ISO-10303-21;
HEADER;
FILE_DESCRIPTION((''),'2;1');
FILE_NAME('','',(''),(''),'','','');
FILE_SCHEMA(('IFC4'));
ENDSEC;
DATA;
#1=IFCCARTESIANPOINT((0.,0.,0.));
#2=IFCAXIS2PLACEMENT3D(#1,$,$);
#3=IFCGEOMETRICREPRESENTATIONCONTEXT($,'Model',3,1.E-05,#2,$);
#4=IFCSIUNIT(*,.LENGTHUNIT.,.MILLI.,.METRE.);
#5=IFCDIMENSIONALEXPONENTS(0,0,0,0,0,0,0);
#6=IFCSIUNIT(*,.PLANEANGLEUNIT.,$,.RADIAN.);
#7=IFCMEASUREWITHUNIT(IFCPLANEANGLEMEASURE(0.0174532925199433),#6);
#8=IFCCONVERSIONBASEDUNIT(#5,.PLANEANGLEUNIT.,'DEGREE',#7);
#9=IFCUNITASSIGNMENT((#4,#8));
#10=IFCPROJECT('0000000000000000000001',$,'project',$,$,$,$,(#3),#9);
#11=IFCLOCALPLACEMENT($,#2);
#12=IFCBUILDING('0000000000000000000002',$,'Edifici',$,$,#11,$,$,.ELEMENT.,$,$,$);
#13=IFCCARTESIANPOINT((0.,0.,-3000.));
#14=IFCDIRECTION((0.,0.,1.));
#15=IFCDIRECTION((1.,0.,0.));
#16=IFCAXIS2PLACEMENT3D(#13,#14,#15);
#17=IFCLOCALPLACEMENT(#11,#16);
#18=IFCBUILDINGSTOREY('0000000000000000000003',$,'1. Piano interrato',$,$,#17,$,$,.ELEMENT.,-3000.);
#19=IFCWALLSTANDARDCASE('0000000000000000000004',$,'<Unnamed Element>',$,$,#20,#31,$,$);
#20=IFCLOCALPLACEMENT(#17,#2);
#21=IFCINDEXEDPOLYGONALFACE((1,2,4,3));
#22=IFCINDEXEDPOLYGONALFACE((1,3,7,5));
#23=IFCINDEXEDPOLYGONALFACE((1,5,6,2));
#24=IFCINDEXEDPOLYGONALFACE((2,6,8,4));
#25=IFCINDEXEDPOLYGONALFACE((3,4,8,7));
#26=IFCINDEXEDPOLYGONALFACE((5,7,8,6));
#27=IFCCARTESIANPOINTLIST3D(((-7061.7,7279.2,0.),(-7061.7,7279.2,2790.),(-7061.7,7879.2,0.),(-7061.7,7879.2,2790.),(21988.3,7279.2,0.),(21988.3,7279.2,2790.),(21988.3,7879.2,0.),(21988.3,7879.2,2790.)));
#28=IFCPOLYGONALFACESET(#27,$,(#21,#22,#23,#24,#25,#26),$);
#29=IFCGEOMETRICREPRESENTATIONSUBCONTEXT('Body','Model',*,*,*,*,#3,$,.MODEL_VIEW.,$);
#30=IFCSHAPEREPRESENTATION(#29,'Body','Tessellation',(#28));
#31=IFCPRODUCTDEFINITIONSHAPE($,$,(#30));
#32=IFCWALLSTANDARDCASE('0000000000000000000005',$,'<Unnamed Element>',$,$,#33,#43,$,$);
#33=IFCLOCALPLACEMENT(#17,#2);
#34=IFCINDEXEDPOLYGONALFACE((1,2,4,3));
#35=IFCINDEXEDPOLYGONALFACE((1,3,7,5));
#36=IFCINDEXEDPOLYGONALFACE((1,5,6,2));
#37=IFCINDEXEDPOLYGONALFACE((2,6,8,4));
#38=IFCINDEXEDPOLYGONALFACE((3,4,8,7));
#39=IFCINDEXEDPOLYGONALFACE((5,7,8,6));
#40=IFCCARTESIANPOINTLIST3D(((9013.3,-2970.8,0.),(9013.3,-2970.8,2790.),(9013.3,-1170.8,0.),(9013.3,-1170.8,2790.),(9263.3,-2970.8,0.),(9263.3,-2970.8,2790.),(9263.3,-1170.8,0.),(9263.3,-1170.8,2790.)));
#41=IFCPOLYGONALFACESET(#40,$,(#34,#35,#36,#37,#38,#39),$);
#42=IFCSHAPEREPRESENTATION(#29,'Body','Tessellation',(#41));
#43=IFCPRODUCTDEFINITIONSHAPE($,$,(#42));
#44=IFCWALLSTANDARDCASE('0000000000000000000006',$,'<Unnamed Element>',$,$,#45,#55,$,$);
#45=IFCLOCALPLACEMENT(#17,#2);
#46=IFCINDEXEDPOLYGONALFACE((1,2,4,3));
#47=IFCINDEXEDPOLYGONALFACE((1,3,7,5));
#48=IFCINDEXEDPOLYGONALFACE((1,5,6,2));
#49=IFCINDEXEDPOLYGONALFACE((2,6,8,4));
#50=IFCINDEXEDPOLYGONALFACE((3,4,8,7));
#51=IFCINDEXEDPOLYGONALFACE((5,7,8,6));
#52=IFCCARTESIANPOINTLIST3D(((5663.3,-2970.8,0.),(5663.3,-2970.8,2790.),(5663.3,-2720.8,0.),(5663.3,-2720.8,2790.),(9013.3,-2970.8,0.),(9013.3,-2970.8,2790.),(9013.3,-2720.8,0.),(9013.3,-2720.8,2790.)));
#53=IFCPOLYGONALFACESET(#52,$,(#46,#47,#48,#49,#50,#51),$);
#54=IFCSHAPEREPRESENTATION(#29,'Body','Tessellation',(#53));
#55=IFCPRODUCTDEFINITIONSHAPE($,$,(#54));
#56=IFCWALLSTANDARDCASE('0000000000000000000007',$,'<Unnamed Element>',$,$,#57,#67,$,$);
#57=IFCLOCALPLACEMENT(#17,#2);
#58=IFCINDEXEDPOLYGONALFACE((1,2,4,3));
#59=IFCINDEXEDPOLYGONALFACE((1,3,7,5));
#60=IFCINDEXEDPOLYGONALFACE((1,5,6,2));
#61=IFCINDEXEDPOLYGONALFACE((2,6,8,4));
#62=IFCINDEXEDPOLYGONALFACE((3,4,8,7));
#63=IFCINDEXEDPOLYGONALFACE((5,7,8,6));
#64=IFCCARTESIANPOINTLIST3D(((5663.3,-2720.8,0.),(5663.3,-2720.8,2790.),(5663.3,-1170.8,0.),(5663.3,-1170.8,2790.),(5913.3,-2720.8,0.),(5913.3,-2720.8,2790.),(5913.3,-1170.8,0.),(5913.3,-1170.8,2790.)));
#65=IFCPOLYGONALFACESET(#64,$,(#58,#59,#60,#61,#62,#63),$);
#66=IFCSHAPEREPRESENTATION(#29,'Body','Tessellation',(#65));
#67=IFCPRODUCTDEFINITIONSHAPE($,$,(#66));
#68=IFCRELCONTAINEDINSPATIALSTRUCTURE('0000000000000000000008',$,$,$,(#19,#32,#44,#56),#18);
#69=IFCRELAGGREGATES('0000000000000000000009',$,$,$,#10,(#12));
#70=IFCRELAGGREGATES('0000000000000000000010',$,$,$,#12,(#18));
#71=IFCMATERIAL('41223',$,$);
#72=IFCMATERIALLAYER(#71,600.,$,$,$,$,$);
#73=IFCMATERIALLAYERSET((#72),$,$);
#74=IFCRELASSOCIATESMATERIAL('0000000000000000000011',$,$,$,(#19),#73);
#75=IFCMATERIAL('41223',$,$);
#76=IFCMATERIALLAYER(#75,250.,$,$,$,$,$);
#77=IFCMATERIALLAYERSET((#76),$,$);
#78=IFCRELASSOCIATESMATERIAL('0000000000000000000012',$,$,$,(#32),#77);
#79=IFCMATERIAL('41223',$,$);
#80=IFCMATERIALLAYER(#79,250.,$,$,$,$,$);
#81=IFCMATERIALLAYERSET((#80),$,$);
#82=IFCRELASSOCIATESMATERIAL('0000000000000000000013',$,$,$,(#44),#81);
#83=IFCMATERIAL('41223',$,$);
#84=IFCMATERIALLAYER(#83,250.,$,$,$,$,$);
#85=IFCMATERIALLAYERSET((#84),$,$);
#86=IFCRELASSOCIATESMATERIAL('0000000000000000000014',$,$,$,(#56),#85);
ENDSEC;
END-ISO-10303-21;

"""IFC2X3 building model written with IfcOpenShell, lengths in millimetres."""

from ifc_helpers import new_model, entity, si_unit, converted_unit, frame, frame_2d, origin, origin_with_axes, place, context, subcontext, project, spatial, rectangle, extrude, material, layer, layer_set, layer_usage, element, save


model = new_model("IFC2X3")

# Units and contexts
model_context = context("Model", 3, precision=1e-05, world=origin())
body_context = subcontext(model_context, "Body", "Model", "MODEL_VIEW")
ifc_project = project(units=[si_unit("LENGTHUNIT", "METRE", prefix="MILLI"), converted_unit("PLANEANGLEUNIT", "DEGREE", entity("IfcPlaneAngleMeasure", 0.0174532925199433), si_unit("PLANEANGLEUNIT", "RADIAN"), dimensions=[0, 0, 0, 0, 0, 0, 0])], contexts=[model_context])

# Building, storey
building_placement = place(None, origin())
building = spatial("IfcBuilding", under=ifc_project, at=building_placement, Name="Edifici", CompositionType="ELEMENT")
storey_placement = place(building_placement, frame((0.0, 0.0, -3000.0), z_axis=(0.0, 0.0, 1.0), x_axis=(1.0, 0.0, 0.0)))
storey = spatial("IfcBuildingStorey", under=building, at=storey_placement, Name="1. Piano interrato", CompositionType="ELEMENT", Elevation=-3000.0)

# Walls
ifc_material_1 = material(Name="41223")
ifc_layer_1 = layer(ifc_material_1, 600.0)
ifc_layer_set_1 = layer_set([ifc_layer_1])
ifc_layer_usage_1 = layer_usage(ifc_layer_set_1, "AXIS2", "POSITIVE", 0.0)
wall_1_placement = place(storey_placement, frame((21988.3, 7879.2, 0.0), z_axis=(0.0, 0.0, 1.0), x_axis=(-1.0, 0.0, 0.0)))
element("IfcWallStandardCase", 1, at=wall_1_placement, inside=storey, material=ifc_layer_usage_1, Name="<Unnamed Element>", context=body_context, shape_type="SweptSolid", body=[
    extrude(rectangle(XDim=29050.0, YDim=600.0, at=frame_2d((14525.0, 300.0), x_axis=(1.0, 0.0))), origin_with_axes(), (0.0, 0.0, 1.0), 2790.0),
])
ifc_material_2 = material(Name="41223")
ifc_layer_2 = layer(ifc_material_2, 250.0)
ifc_layer_set_2 = layer_set([ifc_layer_2])
ifc_layer_usage_2 = layer_usage(ifc_layer_set_2, "AXIS2", "POSITIVE", 0.0)
wall_2_placement = place(storey_placement, frame((9263.3, -2970.8, 0.0), z_axis=(0.0, 0.0, 1.0), x_axis=(0.0, 1.0, 0.0)))
element("IfcWallStandardCase", 2, at=wall_2_placement, inside=storey, material=ifc_layer_usage_2, Name="<Unnamed Element>", context=body_context, shape_type="SweptSolid", body=[
    extrude(rectangle(XDim=1800.0, YDim=250.0, at=frame_2d((900.0, 125.0), x_axis=(1.0, 0.0))), origin_with_axes(), (0.0, 0.0, 1.0), 2790.0),
])
ifc_material_3 = material(Name="41223")
ifc_layer_3 = layer(ifc_material_3, 250.0)
ifc_layer_set_3 = layer_set([ifc_layer_3])
ifc_layer_usage_3 = layer_usage(ifc_layer_set_3, "AXIS2", "POSITIVE", 0.0)
wall_3_placement = place(storey_placement, frame((5663.3, -2970.8, 0.0), z_axis=(0.0, 0.0, 1.0), x_axis=(1.0, 0.0, 0.0)))
element("IfcWallStandardCase", 3, at=wall_3_placement, inside=storey, material=ifc_layer_usage_3, Name="<Unnamed Element>", context=body_context, shape_type="SweptSolid", body=[
    extrude(rectangle(XDim=3350.0, YDim=250.0, at=frame_2d((1675.0, 125.0), x_axis=(1.0, 0.0))), origin_with_axes(), (0.0, 0.0, 1.0), 2790.0),
])
ifc_material_4 = material(Name="41223")
ifc_layer_4 = layer(ifc_material_4, 250.0)
ifc_layer_set_4 = layer_set([ifc_layer_4])
ifc_layer_usage_4 = layer_usage(ifc_layer_set_4, "AXIS2", "POSITIVE", 0.0)
wall_4_placement = place(storey_placement, frame((5663.3, -1170.8, 0.0), z_axis=(0.0, 0.0, 1.0), x_axis=(0.0, -1.0, 0.0)))
element("IfcWallStandardCase", 4, at=wall_4_placement, inside=storey, material=ifc_layer_usage_4, Name="<Unnamed Element>", context=body_context, shape_type="SweptSolid", body=[
    extrude(rectangle(XDim=1550.0, YDim=250.0, at=frame_2d((775.0, 125.0), x_axis=(1.0, 0.0))), origin_with_axes(), (0.0, 0.0, 1.0), 2790.0),
])

save(model, "model.ifc")
